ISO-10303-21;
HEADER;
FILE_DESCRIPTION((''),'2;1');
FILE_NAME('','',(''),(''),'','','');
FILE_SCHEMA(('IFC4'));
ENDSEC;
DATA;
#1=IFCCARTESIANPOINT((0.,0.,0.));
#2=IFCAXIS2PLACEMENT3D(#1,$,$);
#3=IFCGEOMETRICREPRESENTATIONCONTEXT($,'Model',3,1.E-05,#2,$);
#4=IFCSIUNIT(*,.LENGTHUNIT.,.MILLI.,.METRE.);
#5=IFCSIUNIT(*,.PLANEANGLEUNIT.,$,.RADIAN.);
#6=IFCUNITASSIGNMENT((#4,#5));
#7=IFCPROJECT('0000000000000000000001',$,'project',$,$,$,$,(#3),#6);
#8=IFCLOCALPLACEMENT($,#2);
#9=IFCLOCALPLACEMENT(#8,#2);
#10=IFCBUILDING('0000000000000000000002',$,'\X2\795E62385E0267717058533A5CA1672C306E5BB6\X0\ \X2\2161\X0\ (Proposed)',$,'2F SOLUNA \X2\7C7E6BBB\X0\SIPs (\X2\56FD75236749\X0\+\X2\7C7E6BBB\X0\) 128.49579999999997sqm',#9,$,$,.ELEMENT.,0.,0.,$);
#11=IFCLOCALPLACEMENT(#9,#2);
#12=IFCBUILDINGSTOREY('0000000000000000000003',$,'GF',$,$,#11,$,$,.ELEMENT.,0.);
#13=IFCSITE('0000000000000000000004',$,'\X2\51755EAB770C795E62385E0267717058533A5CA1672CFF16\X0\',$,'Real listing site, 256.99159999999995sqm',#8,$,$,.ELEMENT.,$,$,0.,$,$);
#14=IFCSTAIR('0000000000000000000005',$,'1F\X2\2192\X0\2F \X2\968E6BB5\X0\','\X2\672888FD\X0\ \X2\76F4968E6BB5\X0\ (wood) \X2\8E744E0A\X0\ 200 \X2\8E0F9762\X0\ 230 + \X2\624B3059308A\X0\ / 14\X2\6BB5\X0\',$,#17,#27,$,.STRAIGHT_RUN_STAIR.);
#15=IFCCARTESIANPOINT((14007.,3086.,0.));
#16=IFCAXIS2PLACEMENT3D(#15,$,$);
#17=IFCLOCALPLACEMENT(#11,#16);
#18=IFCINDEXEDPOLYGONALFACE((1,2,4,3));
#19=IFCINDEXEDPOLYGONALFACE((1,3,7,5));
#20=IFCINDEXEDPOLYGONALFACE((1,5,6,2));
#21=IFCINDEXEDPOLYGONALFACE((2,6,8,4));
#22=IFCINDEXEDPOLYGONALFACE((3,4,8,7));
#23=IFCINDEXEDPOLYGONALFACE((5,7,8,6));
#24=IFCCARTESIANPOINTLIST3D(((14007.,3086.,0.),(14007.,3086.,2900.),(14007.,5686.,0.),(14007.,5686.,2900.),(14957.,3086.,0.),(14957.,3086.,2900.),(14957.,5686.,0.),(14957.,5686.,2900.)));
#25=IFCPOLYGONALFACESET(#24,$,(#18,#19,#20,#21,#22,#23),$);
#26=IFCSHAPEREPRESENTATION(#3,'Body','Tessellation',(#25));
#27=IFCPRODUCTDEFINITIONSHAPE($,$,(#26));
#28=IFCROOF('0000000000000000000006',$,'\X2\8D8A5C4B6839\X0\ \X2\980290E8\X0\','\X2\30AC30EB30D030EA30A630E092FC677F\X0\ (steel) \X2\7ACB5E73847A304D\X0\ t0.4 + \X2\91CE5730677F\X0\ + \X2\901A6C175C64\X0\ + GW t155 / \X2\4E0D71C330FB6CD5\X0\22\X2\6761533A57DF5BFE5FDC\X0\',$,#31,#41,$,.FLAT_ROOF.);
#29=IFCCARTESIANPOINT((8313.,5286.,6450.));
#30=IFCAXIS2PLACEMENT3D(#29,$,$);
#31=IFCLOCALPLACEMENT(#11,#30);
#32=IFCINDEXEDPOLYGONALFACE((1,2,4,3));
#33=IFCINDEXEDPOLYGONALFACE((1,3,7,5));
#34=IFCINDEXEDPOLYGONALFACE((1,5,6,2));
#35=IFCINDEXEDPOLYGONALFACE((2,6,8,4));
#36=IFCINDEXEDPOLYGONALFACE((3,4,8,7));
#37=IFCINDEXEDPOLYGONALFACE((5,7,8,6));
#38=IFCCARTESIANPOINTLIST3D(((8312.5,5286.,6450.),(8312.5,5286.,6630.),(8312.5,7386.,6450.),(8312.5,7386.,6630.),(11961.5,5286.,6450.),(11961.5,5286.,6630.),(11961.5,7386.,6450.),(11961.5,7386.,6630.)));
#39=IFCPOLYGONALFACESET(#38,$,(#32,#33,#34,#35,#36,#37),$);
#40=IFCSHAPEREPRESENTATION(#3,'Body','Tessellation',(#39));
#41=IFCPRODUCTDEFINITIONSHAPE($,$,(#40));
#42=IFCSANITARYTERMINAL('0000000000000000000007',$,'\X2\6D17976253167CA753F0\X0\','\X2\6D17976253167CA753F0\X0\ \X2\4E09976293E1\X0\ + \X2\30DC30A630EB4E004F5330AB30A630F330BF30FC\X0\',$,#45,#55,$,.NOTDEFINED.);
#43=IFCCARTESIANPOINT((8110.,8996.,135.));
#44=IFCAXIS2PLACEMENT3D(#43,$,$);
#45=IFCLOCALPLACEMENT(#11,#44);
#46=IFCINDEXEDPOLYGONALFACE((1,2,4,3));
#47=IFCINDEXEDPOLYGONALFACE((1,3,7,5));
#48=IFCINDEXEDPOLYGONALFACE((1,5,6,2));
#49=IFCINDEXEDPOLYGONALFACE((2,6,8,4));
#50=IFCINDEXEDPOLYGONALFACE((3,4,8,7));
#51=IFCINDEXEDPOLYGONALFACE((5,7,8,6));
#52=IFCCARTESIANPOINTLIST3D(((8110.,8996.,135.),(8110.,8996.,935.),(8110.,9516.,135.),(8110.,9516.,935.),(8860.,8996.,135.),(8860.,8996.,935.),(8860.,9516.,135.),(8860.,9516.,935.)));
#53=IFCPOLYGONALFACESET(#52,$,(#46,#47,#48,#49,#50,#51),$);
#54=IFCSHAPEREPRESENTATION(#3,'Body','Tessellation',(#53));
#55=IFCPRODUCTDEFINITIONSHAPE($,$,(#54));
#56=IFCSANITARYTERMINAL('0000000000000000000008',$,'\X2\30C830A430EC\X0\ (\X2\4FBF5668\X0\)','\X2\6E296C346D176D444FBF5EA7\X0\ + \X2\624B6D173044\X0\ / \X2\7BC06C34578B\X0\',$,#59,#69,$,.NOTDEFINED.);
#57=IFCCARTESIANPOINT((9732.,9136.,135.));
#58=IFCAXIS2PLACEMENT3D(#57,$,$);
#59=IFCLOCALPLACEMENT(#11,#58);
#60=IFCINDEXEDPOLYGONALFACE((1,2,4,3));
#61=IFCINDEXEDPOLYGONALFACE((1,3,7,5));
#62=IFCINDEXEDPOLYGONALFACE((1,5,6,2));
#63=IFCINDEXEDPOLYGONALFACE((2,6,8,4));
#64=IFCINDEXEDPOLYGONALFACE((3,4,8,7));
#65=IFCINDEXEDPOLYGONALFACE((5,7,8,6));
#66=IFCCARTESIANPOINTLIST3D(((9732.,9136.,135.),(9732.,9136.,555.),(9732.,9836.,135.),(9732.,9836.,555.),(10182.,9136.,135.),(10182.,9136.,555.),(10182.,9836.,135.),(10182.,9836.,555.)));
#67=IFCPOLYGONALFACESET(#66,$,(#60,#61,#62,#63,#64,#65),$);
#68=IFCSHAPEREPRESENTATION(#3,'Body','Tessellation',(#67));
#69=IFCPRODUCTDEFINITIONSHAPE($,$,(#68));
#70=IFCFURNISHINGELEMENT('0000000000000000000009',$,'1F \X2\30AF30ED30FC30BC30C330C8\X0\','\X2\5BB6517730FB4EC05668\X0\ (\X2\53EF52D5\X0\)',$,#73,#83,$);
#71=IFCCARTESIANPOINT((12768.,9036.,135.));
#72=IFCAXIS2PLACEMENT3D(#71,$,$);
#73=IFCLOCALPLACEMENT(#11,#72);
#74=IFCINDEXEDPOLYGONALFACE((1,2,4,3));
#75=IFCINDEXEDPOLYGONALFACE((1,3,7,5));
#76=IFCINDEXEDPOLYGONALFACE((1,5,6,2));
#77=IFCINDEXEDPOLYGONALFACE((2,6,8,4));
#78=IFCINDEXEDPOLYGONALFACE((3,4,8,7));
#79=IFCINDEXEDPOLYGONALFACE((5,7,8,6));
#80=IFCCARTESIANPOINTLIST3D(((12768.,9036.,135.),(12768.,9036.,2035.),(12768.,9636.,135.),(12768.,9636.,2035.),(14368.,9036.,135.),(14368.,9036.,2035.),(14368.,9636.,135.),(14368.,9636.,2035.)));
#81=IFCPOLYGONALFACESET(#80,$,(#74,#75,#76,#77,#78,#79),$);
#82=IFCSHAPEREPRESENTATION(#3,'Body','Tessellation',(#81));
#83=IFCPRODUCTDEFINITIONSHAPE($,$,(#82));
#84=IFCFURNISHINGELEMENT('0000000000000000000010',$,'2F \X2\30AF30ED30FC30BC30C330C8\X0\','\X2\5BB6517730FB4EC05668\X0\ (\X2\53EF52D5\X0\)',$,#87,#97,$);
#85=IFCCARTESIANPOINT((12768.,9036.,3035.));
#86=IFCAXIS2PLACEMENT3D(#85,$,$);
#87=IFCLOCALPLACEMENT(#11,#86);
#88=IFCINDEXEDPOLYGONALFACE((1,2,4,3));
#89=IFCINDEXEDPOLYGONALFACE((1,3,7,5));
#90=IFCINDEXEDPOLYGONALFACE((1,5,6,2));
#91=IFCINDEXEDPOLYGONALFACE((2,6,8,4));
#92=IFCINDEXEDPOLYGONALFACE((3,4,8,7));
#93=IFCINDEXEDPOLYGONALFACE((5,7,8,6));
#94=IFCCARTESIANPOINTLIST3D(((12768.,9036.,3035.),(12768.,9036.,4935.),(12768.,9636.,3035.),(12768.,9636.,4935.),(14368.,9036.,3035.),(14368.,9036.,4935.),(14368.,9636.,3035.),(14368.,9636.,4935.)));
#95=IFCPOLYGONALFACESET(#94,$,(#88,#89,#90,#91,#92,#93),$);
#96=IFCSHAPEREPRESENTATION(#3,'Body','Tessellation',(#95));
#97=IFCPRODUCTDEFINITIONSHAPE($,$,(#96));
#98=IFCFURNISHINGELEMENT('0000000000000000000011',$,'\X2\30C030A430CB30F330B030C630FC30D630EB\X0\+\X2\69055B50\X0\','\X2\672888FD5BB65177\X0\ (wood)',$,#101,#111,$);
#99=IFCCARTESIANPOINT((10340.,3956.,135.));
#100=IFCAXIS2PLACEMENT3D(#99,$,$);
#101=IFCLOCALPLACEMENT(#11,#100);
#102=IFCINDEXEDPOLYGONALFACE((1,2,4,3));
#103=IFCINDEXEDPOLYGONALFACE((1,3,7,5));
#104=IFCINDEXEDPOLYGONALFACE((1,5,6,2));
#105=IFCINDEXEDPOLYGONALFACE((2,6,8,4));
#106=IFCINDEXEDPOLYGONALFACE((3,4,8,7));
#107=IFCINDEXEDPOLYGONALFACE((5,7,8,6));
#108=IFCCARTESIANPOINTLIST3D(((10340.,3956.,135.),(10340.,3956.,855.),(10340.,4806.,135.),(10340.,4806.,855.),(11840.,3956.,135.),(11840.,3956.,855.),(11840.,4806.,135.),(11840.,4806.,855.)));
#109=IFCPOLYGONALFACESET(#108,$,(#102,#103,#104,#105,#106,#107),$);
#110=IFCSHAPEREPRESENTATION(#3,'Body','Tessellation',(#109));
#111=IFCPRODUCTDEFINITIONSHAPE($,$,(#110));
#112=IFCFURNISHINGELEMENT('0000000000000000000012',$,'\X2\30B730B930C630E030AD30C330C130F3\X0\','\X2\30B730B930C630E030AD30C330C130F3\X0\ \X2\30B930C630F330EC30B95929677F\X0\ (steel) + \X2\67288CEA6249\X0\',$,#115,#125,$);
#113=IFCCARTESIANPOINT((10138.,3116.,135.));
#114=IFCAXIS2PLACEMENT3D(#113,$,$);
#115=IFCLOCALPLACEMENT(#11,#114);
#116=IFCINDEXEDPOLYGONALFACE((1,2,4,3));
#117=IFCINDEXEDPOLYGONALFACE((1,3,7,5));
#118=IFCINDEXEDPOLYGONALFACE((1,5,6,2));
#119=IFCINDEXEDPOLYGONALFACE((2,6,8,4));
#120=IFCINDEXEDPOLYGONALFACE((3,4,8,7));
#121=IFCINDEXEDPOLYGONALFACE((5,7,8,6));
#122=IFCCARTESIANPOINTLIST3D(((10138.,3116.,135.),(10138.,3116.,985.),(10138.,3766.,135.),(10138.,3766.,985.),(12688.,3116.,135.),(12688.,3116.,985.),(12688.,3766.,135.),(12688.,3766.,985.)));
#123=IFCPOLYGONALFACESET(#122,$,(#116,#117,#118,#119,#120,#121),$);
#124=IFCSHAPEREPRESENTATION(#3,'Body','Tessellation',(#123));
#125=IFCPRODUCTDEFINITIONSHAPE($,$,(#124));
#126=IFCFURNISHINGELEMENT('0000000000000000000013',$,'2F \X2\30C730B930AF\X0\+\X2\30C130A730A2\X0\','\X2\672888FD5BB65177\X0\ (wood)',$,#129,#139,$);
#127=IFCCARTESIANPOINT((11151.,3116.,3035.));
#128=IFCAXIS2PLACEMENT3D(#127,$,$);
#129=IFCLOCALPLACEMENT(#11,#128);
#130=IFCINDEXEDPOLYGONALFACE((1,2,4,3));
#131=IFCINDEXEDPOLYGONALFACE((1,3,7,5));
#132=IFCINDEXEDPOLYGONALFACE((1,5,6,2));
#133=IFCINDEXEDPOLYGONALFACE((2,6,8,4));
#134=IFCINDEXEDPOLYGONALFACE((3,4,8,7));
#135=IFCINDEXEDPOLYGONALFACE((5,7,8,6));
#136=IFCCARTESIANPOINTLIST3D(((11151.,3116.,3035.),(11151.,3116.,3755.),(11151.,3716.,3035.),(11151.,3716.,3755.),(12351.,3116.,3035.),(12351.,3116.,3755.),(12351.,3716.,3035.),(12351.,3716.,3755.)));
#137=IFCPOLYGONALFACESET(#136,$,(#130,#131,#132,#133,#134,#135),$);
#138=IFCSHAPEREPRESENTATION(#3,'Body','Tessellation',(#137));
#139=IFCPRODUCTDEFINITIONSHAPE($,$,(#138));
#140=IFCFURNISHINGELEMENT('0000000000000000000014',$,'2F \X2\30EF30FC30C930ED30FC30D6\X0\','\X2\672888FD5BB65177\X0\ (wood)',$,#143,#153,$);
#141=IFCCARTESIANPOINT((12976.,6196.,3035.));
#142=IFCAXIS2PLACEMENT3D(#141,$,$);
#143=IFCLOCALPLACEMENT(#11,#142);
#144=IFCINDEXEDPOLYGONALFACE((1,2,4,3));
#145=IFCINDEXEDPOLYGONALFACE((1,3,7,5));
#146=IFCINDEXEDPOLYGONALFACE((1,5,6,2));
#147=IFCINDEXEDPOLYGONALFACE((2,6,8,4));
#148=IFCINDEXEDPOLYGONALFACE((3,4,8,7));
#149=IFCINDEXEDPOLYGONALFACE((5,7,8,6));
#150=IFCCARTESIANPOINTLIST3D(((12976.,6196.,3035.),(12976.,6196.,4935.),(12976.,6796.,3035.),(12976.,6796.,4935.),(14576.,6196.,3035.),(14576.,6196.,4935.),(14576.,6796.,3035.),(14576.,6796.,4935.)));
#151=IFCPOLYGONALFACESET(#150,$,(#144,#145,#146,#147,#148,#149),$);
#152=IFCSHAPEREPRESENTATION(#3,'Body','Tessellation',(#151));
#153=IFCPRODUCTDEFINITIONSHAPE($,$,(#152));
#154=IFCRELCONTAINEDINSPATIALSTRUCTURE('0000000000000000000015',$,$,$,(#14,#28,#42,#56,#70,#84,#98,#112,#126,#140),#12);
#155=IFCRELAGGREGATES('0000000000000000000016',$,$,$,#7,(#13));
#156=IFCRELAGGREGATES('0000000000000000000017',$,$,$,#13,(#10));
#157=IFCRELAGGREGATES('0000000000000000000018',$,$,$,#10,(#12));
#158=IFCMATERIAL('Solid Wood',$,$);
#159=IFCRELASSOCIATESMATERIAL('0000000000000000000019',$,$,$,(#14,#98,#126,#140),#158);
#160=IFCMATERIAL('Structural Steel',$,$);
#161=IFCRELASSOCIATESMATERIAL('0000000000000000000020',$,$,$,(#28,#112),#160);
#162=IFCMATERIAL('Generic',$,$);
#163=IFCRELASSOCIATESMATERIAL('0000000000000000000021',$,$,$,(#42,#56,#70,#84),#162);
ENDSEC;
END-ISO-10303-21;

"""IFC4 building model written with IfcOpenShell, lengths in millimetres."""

from ifc_helpers import new_model, si_unit, frame, frame_2d, origin, place, context, project, spatial, rectangle, extrude, material, element, save


model = new_model("IFC4")

# Units and contexts
model_context = context("Model", 3, precision=1e-05, world=origin())
ifc_project = project(units=[si_unit("LENGTHUNIT", "METRE", prefix="MILLI"), si_unit("PLANEANGLEUNIT", "RADIAN")], contexts=[model_context])

# Site, building, storey
site_placement = place(None, origin())
site = spatial("IfcSite", under=ifc_project, at=site_placement, Name="兵庫県神戸市東灘区岡本６", ObjectType="Real listing site, 256.99159999999995sqm", CompositionType="ELEMENT", RefElevation=0.0)
building_placement = place(site_placement, origin())
building = spatial("IfcBuilding", under=site, at=building_placement, Name="神戸市東灘区岡本の家 Ⅱ (Proposed)", ObjectType="2F SOLUNA 籾殻SIPs (国産杉+籾殻) 128.49579999999997sqm", CompositionType="ELEMENT", ElevationOfRefHeight=0.0, ElevationOfTerrain=0.0)
storey_placement = place(building_placement, origin())
storey = spatial("IfcBuildingStorey", under=building, at=storey_placement, Name="GF", CompositionType="ELEMENT", Elevation=0.0)

# Shared definitions
ifc_material_1 = material(Name="Solid Wood")

# Stair
stair_placement = place(storey_placement, frame((14007.0, 3086.0, 0.0)))
element("IfcStair", 1, at=stair_placement, inside=storey, material=ifc_material_1, Name="1F→2F 階段", Description="木製 直階段 (wood) 蹴上 200 踏面 230 + 手すり / 14段", PredefinedType="STRAIGHT_RUN_STAIR", context=model_context, shape_type="SweptSolid", body=[
    extrude(rectangle(XDim=950.0, YDim=2600.0, at=frame_2d((475.0, 1300.0))), frame((14007.0, 3086.0, 0.0)), (0.0, 0.0, 1.0), 2900.0),
])

# Roof
ifc_material_2 = material(Name="Structural Steel")
roof_placement = place(storey_placement, frame((8313.0, 5286.0, 6450.0)))
element("IfcRoof", 2, at=roof_placement, inside=storey, material=ifc_material_2, Name="越屋根 頂部", Description="ガルバリウム鋼板 (steel) 立平葺き t0.4 + 野地板 + 通気層 + GW t155 / 不燃・法22条区域対応", PredefinedType="FLAT_ROOF", context=model_context, shape_type="SweptSolid", body=[
    extrude(rectangle(XDim=3649.0, YDim=2100.0, at=frame_2d((1824.0, 1050.0))), frame((8313.0, 5286.0, 6450.0)), (0.0, 0.0, 1.0), 180.0),
])

# Sanitary terminals
ifc_material_3 = material(Name="Generic")
sanitary_terminal_1_placement = place(storey_placement, frame((8110.0, 8996.0, 135.0)))
element("IfcSanitaryTerminal", 3, at=sanitary_terminal_1_placement, inside=storey, material=ifc_material_3, Name="洗面化粧台", Description="洗面化粧台 三面鏡 + ボウル一体カウンター", PredefinedType="NOTDEFINED", context=model_context, shape_type="SweptSolid", body=[
    extrude(rectangle(XDim=750.0, YDim=520.0, at=frame_2d((375.0, 260.0))), frame((8110.0, 8996.0, 135.0)), (0.0, 0.0, 1.0), 800.0),
])
sanitary_terminal_2_placement = place(storey_placement, frame((9732.0, 9136.0, 135.0)))
element("IfcSanitaryTerminal", 4, at=sanitary_terminal_2_placement, inside=storey, material=ifc_material_3, Name="トイレ (便器)", Description="温水洗浄便座 + 手洗い / 節水型", PredefinedType="NOTDEFINED", context=model_context, shape_type="SweptSolid", body=[
    extrude(rectangle(XDim=450.0, YDim=700.0, at=frame_2d((225.0, 350.0))), frame((9732.0, 9136.0, 135.0)), (0.0, 0.0, 1.0), 420.0),
])

# Furnishing elements
furnishing_1_placement = place(storey_placement, frame((12768.0, 9036.0, 135.0)))
element("IfcFurnishingElement", 5, at=furnishing_1_placement, inside=storey, material=ifc_material_3, Name="1F クローゼット", Description="家具・什器 (可動)", context=model_context, shape_type="SweptSolid", body=[
    extrude(rectangle(XDim=1600.0, YDim=600.0, at=frame_2d((800.0, 300.0))), frame((12768.0, 9036.0, 135.0)), (0.0, 0.0, 1.0), 1900.0),
])
furnishing_2_placement = place(storey_placement, frame((12768.0, 9036.0, 3035.0)))
element("IfcFurnishingElement", 6, at=furnishing_2_placement, inside=storey, material=ifc_material_3, Name="2F クローゼット", Description="家具・什器 (可動)", context=model_context, shape_type="SweptSolid", body=[
    extrude(rectangle(XDim=1600.0, YDim=600.0, at=frame_2d((800.0, 300.0))), frame((12768.0, 9036.0, 3035.0)), (0.0, 0.0, 1.0), 1900.0),
])
furnishing_3_placement = place(storey_placement, frame((10340.0, 3956.0, 135.0)))
element("IfcFurnishingElement", 7, at=furnishing_3_placement, inside=storey, material=ifc_material_1, Name="ダイニングテーブル+椅子", Description="木製家具 (wood)", context=model_context, shape_type="SweptSolid", body=[
    extrude(rectangle(XDim=1500.0, YDim=850.0, at=frame_2d((750.0, 425.0))), frame((10340.0, 3956.0, 135.0)), (0.0, 0.0, 1.0), 720.0),
])
furnishing_4_placement = place(storey_placement, frame((10138.0, 3116.0, 135.0)))
element("IfcFurnishingElement", 8, at=furnishing_4_placement, inside=storey, material=ifc_material_2, Name="システムキッチン", Description="システムキッチン ステンレス天板 (steel) + 木質扉", context=model_context, shape_type="SweptSolid", body=[
    extrude(rectangle(XDim=2550.0, YDim=650.0, at=frame_2d((1275.0, 325.0))), frame((10138.0, 3116.0, 135.0)), (0.0, 0.0, 1.0), 850.0),
])
furnishing_5_placement = place(storey_placement, frame((11151.0, 3116.0, 3035.0)))
element("IfcFurnishingElement", 9, at=furnishing_5_placement, inside=storey, material=ifc_material_1, Name="2F デスク+チェア", Description="木製家具 (wood)", context=model_context, shape_type="SweptSolid", body=[
    extrude(rectangle(XDim=1200.0, YDim=600.0, at=frame_2d((600.0, 300.0))), frame((11151.0, 3116.0, 3035.0)), (0.0, 0.0, 1.0), 720.0),
])
furnishing_6_placement = place(storey_placement, frame((12976.0, 6196.0, 3035.0)))
element("IfcFurnishingElement", 10, at=furnishing_6_placement, inside=storey, material=ifc_material_1, Name="2F ワードローブ", Description="木製家具 (wood)", context=model_context, shape_type="SweptSolid", body=[
    extrude(rectangle(XDim=1600.0, YDim=600.0, at=frame_2d((800.0, 300.0))), frame((12976.0, 6196.0, 3035.0)), (0.0, 0.0, 1.0), 1900.0),
])

save(model, "model.ifc")
